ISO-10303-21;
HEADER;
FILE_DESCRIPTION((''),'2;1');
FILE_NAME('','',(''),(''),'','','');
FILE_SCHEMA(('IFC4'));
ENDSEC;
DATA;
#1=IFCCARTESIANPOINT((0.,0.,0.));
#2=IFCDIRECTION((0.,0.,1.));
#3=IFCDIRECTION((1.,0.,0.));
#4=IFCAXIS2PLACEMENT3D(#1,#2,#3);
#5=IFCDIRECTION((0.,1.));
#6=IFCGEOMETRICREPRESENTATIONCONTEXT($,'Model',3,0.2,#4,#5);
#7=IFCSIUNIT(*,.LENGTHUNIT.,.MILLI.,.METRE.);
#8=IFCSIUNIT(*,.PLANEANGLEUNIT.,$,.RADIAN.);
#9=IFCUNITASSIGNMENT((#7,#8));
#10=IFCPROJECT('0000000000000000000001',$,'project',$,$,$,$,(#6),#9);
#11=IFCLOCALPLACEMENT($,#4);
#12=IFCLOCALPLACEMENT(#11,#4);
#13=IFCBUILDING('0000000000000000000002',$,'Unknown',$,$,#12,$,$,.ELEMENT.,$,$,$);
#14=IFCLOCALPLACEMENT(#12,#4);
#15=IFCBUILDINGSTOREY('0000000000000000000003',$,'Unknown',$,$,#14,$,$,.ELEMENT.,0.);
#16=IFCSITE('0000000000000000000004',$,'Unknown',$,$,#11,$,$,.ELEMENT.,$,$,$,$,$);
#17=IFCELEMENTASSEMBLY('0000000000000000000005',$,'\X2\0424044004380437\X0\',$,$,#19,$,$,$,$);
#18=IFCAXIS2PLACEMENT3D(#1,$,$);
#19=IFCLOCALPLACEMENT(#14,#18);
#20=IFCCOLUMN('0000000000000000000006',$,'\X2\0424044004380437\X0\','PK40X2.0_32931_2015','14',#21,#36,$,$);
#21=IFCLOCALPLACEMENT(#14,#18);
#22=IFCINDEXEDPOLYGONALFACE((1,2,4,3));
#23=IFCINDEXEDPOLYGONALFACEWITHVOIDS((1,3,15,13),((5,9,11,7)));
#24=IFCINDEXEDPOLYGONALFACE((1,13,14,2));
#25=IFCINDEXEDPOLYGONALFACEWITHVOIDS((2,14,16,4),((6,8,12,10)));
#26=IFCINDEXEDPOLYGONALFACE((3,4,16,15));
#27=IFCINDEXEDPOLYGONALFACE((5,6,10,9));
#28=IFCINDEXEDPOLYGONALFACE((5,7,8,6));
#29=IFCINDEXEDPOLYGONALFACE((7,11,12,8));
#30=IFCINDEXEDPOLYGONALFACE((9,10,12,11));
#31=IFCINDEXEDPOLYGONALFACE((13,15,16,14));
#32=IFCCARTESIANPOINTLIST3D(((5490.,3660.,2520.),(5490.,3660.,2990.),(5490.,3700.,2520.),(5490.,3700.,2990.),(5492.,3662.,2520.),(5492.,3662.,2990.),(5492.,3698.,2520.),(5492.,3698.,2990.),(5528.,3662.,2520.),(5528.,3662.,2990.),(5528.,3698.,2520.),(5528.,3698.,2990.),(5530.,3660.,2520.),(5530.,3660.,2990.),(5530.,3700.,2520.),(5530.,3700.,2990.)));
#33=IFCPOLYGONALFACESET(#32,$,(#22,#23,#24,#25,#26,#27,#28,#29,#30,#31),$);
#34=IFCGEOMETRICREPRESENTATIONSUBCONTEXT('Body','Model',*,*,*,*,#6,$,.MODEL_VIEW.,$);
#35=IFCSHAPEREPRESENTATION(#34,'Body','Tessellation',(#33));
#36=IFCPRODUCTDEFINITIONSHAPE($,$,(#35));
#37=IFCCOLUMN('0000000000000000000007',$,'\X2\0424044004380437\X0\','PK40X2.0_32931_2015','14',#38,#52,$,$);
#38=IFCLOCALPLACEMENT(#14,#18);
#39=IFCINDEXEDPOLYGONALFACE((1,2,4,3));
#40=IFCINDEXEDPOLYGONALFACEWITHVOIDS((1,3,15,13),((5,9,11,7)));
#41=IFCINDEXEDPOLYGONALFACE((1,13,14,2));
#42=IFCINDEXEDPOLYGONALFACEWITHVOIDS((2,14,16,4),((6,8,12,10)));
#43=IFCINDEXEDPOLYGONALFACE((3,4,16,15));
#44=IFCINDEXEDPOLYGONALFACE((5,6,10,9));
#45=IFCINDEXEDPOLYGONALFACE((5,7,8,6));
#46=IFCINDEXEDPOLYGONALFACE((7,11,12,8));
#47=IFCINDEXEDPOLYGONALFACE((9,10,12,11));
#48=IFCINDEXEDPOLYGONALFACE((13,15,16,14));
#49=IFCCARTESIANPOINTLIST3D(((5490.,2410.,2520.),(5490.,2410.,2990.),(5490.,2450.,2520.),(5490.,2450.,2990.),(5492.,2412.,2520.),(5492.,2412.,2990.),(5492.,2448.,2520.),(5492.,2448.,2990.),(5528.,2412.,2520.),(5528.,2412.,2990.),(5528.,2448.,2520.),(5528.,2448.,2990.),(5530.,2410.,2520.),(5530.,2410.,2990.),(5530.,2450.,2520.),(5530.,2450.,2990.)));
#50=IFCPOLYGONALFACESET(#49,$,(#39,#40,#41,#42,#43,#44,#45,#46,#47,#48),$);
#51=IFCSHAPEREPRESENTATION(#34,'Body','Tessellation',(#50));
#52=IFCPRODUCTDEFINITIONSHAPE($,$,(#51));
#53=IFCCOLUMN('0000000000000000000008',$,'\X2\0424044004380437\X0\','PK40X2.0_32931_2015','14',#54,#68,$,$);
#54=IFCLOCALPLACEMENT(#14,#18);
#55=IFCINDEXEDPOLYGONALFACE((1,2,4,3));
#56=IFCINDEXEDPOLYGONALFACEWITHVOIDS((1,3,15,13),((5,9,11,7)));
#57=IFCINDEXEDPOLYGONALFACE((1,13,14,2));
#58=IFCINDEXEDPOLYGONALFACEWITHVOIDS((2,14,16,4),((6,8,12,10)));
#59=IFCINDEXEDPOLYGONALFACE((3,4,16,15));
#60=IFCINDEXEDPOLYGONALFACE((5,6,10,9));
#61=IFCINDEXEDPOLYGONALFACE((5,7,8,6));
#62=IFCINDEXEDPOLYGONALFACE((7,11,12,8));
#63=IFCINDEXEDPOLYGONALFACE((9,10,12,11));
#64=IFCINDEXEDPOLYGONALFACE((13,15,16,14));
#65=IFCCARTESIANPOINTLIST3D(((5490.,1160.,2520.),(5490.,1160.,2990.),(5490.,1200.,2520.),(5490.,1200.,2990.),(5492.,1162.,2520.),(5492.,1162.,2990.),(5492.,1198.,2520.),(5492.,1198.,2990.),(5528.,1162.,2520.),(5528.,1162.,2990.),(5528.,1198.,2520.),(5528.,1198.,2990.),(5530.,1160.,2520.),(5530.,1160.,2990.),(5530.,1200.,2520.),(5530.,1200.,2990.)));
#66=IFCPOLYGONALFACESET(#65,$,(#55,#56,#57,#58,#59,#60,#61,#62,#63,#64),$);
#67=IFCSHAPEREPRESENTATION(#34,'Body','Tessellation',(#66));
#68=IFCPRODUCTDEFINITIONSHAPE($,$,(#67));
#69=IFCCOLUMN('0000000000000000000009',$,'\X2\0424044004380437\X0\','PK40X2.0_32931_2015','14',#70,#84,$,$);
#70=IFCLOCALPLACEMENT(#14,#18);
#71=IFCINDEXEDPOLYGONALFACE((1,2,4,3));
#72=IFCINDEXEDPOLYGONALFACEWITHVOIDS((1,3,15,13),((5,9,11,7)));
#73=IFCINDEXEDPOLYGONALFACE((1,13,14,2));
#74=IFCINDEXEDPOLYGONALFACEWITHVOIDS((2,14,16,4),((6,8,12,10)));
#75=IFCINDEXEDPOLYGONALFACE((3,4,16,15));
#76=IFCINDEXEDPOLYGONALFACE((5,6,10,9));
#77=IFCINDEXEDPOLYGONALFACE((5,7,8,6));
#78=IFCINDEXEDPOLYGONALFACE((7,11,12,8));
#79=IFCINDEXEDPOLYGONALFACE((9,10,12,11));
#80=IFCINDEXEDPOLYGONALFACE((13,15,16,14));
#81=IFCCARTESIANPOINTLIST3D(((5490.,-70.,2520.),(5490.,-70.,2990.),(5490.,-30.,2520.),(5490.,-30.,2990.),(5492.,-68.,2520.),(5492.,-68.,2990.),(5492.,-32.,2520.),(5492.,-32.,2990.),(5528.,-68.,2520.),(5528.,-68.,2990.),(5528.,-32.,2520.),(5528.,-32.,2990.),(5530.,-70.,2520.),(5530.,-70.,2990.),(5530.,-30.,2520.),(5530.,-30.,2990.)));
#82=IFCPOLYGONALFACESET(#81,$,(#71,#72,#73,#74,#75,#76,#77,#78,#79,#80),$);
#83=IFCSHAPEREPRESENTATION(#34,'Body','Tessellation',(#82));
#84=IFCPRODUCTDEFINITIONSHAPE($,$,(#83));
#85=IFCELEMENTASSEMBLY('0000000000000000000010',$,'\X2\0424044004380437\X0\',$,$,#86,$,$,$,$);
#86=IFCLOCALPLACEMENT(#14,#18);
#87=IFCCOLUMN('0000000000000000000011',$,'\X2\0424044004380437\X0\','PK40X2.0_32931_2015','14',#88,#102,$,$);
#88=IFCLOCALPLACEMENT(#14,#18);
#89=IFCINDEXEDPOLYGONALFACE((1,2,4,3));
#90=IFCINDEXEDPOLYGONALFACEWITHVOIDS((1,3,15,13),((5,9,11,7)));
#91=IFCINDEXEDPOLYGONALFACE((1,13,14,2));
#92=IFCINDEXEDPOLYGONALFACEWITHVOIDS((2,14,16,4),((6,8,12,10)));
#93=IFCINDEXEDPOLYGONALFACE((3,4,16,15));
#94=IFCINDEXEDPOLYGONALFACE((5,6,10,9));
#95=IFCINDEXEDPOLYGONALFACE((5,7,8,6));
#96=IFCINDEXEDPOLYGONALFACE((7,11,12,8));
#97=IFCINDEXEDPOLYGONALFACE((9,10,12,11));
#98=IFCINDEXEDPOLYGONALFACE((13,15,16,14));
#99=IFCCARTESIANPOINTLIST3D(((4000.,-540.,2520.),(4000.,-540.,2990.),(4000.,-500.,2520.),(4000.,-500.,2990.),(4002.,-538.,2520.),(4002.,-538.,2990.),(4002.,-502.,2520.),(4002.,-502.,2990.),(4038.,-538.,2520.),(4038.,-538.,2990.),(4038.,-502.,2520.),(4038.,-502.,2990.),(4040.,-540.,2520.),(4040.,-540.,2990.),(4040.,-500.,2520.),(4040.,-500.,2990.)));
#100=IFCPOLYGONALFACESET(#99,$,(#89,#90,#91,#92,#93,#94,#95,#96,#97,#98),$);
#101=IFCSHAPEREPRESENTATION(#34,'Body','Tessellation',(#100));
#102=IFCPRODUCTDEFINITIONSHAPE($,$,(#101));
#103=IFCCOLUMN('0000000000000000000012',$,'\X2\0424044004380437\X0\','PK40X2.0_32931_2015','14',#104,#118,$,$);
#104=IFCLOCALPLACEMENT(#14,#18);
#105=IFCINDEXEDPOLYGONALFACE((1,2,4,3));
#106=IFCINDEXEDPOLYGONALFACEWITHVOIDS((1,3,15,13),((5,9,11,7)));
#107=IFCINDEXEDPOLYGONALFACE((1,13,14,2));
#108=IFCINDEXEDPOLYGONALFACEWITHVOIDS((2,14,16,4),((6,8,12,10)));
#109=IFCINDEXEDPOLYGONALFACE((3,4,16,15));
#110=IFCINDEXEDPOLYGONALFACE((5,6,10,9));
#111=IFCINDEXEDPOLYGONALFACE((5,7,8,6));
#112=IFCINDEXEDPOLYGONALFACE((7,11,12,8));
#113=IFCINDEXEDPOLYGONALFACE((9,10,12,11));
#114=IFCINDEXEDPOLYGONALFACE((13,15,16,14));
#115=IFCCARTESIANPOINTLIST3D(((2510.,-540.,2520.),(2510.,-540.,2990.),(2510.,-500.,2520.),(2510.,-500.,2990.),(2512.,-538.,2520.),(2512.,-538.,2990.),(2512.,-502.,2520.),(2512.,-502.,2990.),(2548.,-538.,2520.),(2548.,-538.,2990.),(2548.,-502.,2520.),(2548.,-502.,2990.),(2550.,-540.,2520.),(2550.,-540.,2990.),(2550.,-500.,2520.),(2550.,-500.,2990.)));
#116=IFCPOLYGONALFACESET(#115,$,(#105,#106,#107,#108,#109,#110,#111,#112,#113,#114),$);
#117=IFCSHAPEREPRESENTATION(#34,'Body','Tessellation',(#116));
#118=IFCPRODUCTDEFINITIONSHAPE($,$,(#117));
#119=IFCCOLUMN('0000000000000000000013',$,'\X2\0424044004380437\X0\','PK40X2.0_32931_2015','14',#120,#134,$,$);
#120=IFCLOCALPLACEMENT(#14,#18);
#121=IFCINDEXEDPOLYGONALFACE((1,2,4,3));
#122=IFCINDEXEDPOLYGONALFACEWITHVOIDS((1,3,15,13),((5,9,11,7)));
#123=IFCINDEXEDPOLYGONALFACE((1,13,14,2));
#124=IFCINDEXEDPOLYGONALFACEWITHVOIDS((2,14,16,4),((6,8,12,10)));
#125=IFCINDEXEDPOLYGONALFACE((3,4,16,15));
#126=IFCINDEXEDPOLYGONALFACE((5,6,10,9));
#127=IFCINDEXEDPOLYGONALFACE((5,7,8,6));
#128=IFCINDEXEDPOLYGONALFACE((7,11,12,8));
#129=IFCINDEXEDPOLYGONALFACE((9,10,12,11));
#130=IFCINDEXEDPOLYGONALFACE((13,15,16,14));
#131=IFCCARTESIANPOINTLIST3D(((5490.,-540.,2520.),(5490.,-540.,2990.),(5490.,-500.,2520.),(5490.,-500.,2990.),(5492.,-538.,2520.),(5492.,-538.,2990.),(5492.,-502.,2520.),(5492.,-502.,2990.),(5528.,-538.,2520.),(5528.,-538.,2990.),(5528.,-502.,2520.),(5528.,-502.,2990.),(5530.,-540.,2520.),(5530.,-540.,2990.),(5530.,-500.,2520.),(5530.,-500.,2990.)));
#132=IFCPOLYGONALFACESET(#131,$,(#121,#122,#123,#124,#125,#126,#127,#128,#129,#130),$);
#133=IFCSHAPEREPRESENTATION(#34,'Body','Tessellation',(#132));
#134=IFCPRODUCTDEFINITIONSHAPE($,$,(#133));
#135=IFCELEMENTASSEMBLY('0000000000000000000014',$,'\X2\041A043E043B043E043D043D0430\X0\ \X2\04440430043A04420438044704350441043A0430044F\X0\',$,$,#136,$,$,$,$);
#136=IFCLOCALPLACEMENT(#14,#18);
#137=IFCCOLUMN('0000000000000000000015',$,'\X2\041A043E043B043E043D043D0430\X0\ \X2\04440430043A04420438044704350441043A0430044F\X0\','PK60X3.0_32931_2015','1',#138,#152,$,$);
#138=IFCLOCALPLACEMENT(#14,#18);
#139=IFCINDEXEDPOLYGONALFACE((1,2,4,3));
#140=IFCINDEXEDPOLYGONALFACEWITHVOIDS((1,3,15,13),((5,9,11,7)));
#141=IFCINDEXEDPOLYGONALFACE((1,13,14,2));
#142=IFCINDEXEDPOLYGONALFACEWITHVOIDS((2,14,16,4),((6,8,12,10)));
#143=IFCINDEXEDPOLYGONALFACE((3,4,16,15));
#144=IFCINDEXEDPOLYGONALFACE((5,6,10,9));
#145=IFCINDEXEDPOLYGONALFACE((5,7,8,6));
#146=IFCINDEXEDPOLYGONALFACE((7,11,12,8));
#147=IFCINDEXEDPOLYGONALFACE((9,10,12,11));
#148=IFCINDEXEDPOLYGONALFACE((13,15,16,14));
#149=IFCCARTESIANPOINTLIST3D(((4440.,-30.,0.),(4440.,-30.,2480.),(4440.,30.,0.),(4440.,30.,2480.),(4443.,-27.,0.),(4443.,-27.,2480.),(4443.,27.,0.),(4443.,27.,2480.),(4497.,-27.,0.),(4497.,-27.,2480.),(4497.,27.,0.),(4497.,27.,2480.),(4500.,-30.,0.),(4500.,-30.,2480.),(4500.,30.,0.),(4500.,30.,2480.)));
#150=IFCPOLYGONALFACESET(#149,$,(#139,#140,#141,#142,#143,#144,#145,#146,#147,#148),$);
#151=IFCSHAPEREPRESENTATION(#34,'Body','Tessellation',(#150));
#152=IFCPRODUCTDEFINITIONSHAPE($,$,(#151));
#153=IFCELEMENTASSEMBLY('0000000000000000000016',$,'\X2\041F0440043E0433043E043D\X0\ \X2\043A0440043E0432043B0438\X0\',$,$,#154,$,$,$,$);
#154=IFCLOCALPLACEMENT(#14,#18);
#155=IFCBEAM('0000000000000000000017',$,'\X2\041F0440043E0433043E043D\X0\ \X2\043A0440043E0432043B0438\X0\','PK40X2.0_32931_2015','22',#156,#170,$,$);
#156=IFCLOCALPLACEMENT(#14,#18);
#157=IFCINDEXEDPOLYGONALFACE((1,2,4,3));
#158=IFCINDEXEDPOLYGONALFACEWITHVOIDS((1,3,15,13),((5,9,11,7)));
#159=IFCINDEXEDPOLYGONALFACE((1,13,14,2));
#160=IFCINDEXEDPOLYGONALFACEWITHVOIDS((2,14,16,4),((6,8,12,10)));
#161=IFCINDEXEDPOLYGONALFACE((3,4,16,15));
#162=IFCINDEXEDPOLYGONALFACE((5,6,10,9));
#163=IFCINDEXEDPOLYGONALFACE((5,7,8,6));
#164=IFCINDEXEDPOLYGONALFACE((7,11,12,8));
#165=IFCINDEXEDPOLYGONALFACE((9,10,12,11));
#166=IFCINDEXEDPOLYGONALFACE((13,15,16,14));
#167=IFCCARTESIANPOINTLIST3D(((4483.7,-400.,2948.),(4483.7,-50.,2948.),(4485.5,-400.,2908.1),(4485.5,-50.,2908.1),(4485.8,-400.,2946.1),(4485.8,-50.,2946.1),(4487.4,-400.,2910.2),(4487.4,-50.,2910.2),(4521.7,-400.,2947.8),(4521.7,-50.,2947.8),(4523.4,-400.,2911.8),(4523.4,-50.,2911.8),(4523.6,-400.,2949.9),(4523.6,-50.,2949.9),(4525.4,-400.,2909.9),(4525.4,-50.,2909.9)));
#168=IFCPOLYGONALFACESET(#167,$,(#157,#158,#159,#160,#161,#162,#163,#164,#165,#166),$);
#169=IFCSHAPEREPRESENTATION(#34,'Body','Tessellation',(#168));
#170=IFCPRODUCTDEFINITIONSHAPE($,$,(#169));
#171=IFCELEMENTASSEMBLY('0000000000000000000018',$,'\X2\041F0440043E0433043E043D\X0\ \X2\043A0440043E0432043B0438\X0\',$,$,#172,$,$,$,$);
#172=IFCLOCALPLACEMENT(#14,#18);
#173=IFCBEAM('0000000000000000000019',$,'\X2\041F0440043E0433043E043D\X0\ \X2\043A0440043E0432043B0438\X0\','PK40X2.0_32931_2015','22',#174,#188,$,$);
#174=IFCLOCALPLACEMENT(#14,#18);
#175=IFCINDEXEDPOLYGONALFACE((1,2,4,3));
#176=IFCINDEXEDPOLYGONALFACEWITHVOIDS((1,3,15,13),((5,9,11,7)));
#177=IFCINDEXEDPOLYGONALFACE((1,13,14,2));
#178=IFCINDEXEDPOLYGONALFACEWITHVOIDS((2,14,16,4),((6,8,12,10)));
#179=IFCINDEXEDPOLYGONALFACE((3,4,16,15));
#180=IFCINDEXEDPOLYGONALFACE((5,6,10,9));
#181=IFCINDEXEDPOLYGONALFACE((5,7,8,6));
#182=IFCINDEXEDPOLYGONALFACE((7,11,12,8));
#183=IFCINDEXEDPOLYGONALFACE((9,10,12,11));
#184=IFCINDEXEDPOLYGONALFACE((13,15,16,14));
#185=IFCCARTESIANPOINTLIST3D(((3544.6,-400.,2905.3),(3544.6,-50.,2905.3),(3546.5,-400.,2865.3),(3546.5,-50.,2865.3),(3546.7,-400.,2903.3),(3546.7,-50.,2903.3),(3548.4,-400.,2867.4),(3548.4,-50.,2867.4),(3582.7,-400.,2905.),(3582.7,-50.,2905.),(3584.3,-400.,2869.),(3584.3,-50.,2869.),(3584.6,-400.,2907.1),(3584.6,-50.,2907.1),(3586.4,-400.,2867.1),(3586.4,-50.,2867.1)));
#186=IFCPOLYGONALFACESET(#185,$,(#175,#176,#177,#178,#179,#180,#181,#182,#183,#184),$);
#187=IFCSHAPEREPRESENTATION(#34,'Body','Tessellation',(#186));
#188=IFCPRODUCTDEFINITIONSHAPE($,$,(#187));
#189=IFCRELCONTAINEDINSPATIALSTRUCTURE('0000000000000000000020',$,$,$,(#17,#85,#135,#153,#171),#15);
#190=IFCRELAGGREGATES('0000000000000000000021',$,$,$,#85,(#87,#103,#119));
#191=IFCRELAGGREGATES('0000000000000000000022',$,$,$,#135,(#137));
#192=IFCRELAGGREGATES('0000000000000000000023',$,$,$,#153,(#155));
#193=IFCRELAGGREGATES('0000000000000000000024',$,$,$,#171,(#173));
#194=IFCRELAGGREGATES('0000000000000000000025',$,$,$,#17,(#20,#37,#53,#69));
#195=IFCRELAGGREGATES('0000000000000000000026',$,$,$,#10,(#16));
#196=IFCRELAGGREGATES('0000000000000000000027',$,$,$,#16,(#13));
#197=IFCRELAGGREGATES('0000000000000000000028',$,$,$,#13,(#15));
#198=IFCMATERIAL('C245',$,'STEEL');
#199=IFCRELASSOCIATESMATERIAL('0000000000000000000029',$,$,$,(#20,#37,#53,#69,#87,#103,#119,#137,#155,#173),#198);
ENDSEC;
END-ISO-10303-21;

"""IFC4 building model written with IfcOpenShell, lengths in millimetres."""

from ifc_helpers import new_model, si_unit, direction, frame, origin_with_axes, place, context, subcontext, project, spatial, line, indexed_curve, outline, extrude, material, element, aggregate, save


model = new_model("IFC4")

# Units and contexts
model_context = context("Model", 3, precision=0.2, world=origin_with_axes(), true_north=direction((0.0, 1.0)))
body_context = subcontext(model_context, "Body", "Model", "MODEL_VIEW")
ifc_project = project(units=[si_unit("LENGTHUNIT", "METRE", prefix="MILLI"), si_unit("PLANEANGLEUNIT", "RADIAN")], contexts=[model_context])

# Site, building, storey
site_placement = place(None, origin_with_axes())
site = spatial("IfcSite", under=ifc_project, at=site_placement, Name="Unknown", CompositionType="ELEMENT")
building_placement = place(site_placement, origin_with_axes())
building = spatial("IfcBuilding", under=site, at=building_placement, Name="Unknown", CompositionType="ELEMENT")
storey_placement = place(building_placement, origin_with_axes())
storey = spatial("IfcBuildingStorey", under=building, at=storey_placement, Name="Unknown", CompositionType="ELEMENT", Elevation=0.0)

# Element assemblies, columns
assembly_1_placement = place(storey_placement, frame((5510.0, -500.0, 3010.0), z_axis=(1.0, 0.0, 0.0), x_axis=(0.0, 1.0, 0.0)))
assembly_1 = element("IfcElementAssembly", 1, at=assembly_1_placement, inside=storey, Name="Фриз")
ifc_material = material(Name="C245", Category="STEEL")
column_1_placement = place(assembly_1_placement, frame((4180.0, -490.0, 0.0), z_axis=(-1.0, 0.0, 0.0), x_axis=(0.0, 1.0, 0.0)))
column_1 = element("IfcColumn", 2, at=column_1_placement, material=ifc_material, Name="Фриз", Description="PK40X2.0_32931_2015", ObjectType="14", context=body_context, shape_type="SolidModel", body=[
    extrude(outline(indexed_curve([(-20.0, -20.0), (20.0, -20.0), (20.0, 20.0), (-20.0, 20.0)], segments=[line(1, 2, 3, 4, 1)]), holes=[indexed_curve([(-18.0, -18.0), (-18.0, 18.0), (18.0, 18.0), (18.0, -18.0)], segments=[line(1, 2, 3, 4, 1)])]), frame((0.0, 0.0, 0.0), z_axis=(-1.0, 0.0, 0.0), x_axis=(0.0, 0.0, 1.0)), (0.0, 0.0, -1.0), 470.0),
])
column_2_placement = place(assembly_1_placement, frame((2930.0, -490.0, 0.0), z_axis=(-1.0, 0.0, 0.0), x_axis=(0.0, 1.0, 0.0)))
column_2 = element("IfcColumn", 3, at=column_2_placement, material=ifc_material, Name="Фриз", Description="PK40X2.0_32931_2015", ObjectType="14", context=body_context, shape_type="SolidModel", body=[
    extrude(outline(indexed_curve([(-20.0, -20.0), (20.0, -20.0), (20.0, 20.0), (-20.0, 20.0)], segments=[line(1, 2, 3, 4, 1)]), holes=[indexed_curve([(-18.0, -18.0), (-18.0, 18.0), (18.0, 18.0), (18.0, -18.0)], segments=[line(1, 2, 3, 4, 1)])]), frame((0.0, 0.0, 0.0), z_axis=(-1.0, 0.0, 0.0), x_axis=(0.0, 0.0, 1.0)), (0.0, 0.0, -1.0), 470.0),
])
column_3_placement = place(assembly_1_placement, frame((1680.0, -490.0, 0.0), z_axis=(-1.0, 0.0, 0.0), x_axis=(0.0, 1.0, 0.0)))
column_3 = element("IfcColumn", 4, at=column_3_placement, material=ifc_material, Name="Фриз", Description="PK40X2.0_32931_2015", ObjectType="14", context=body_context, shape_type="SolidModel", body=[
    extrude(outline(indexed_curve([(-20.0, -20.0), (20.0, -20.0), (20.0, 20.0), (-20.0, 20.0)], segments=[line(1, 2, 3, 4, 1)]), holes=[indexed_curve([(-18.0, -18.0), (-18.0, 18.0), (18.0, 18.0), (18.0, -18.0)], segments=[line(1, 2, 3, 4, 1)])]), frame((0.0, 0.0, 0.0), z_axis=(-1.0, 0.0, 0.0), x_axis=(0.0, 0.0, 1.0)), (0.0, 0.0, -1.0), 470.0),
])
column_4_placement = place(assembly_1_placement, frame((450.0, -490.0, 0.0), z_axis=(-1.0, 0.0, 0.0), x_axis=(0.0, 1.0, 0.0)))
column_4 = element("IfcColumn", 5, at=column_4_placement, material=ifc_material, Name="Фриз", Description="PK40X2.0_32931_2015", ObjectType="14", context=body_context, shape_type="SolidModel", body=[
    extrude(outline(indexed_curve([(-20.0, -20.0), (20.0, -20.0), (20.0, 20.0), (-20.0, 20.0)], segments=[line(1, 2, 3, 4, 1)]), holes=[indexed_curve([(-18.0, -18.0), (-18.0, 18.0), (18.0, 18.0), (18.0, -18.0)], segments=[line(1, 2, 3, 4, 1)])]), frame((0.0, 0.0, 0.0), z_axis=(-1.0, 0.0, 0.0), x_axis=(0.0, 0.0, 1.0)), (0.0, 0.0, -1.0), 470.0),
])
assembly_2_placement = place(storey_placement, frame((-470.0, -520.0, 3010.0), z_axis=(0.0, -1.0, 0.0), x_axis=(1.0, 0.0, 0.0)))
assembly_2 = element("IfcElementAssembly", 6, at=assembly_2_placement, inside=storey, Name="Фриз")
column_5_placement = place(assembly_2_placement, frame((4490.0, -490.0, 0.0), z_axis=(0.0, 0.0, -1.0), x_axis=(0.0, 1.0, 0.0)))
column_5 = element("IfcColumn", 7, at=column_5_placement, material=ifc_material, Name="Фриз", Description="PK40X2.0_32931_2015", ObjectType="14", context=body_context, shape_type="SolidModel", body=[
    extrude(outline(indexed_curve([(-20.0, -20.0), (20.0, -20.0), (20.0, 20.0), (-20.0, 20.0)], segments=[line(1, 2, 3, 4, 1)]), holes=[indexed_curve([(-18.0, -18.0), (-18.0, 18.0), (18.0, 18.0), (18.0, -18.0)], segments=[line(1, 2, 3, 4, 1)])]), frame((0.0, 0.0, 0.0), z_axis=(-1.0, 0.0, 0.0), x_axis=(0.0, 0.0, 1.0)), (0.0, 0.0, -1.0), 470.0),
])
column_6_placement = place(assembly_2_placement, frame((3000.0, -490.0, 0.0), z_axis=(0.0, 0.0, -1.0), x_axis=(0.0, 1.0, 0.0)))
column_6 = element("IfcColumn", 8, at=column_6_placement, material=ifc_material, Name="Фриз", Description="PK40X2.0_32931_2015", ObjectType="14", context=body_context, shape_type="SolidModel", body=[
    extrude(outline(indexed_curve([(-20.0, -20.0), (20.0, -20.0), (20.0, 20.0), (-20.0, 20.0)], segments=[line(1, 2, 3, 4, 1)]), holes=[indexed_curve([(-18.0, -18.0), (-18.0, 18.0), (18.0, 18.0), (18.0, -18.0)], segments=[line(1, 2, 3, 4, 1)])]), frame((0.0, 0.0, 0.0), z_axis=(-1.0, 0.0, 0.0), x_axis=(0.0, 0.0, 1.0)), (0.0, 0.0, -1.0), 470.0),
])
column_7_placement = place(assembly_2_placement, frame((5980.0, -490.0, 0.0), z_axis=(0.0, 0.0, 1.0), x_axis=(0.0, 1.0, 0.0)))
column_7 = element("IfcColumn", 9, at=column_7_placement, material=ifc_material, Name="Фриз", Description="PK40X2.0_32931_2015", ObjectType="14", context=body_context, shape_type="SolidModel", body=[
    extrude(outline(indexed_curve([(-20.0, -20.0), (20.0, -20.0), (20.0, 20.0), (-20.0, 20.0)], segments=[line(1, 2, 3, 4, 1)]), holes=[indexed_curve([(-18.0, -18.0), (-18.0, 18.0), (18.0, 18.0), (18.0, -18.0)], segments=[line(1, 2, 3, 4, 1)])]), frame((0.0, 0.0, 0.0), z_axis=(-1.0, 0.0, 0.0), x_axis=(0.0, 0.0, 1.0)), (0.0, 0.0, -1.0), 470.0),
])
aggregate(assembly_2, [column_5, column_6, column_7])

# Element assembly, column
assembly_3_placement = place(storey_placement, frame((4470.0, 0.0, 0.0), z_axis=(-1.0, 0.0, 0.0), x_axis=(0.0, 0.0, 1.0)))
assembly_3 = element("IfcElementAssembly", 10, at=assembly_3_placement, inside=storey, Name="Колонна фактическая")
column_8_placement = place(assembly_3_placement, origin_with_axes())
column_8 = element("IfcColumn", 11, at=column_8_placement, material=ifc_material, Name="Колонна фактическая", Description="PK60X3.0_32931_2015", ObjectType="1", context=body_context, shape_type="SolidModel", body=[
    extrude(outline(indexed_curve([(-30.0, -30.0), (30.0, -30.0), (30.0, 30.0), (-30.0, 30.0)], segments=[line(1, 2, 3, 4, 1)]), holes=[indexed_curve([(-27.0, -27.0), (-27.0, 27.0), (27.0, 27.0), (27.0, -27.0)], segments=[line(1, 2, 3, 4, 1)])]), frame((0.0, 0.0, 0.0), z_axis=(-1.0, 0.0, 0.0), x_axis=(0.0, 0.0, 1.0)), (0.0, 0.0, -1.0), 2480.0),
])
aggregate(assembly_3, [column_8])

# Element assemblies, beams
assembly_4_placement = place(storey_placement, frame((4504.6, -50.0, 2929.0), z_axis=(-0.998964, 0.0, -0.045508), x_axis=(0.0, -1.0, 0.0)))
assembly_4 = element("IfcElementAssembly", 12, at=assembly_4_placement, inside=storey, Name="Прогон кровли")
beam_1_placement = place(assembly_4_placement, origin_with_axes())
beam_1 = element("IfcBeam", 13, at=beam_1_placement, material=ifc_material, Name="Прогон кровли", Description="PK40X2.0_32931_2015", ObjectType="22", context=body_context, shape_type="SolidModel", body=[
    extrude(outline(indexed_curve([(-20.0, -20.0), (20.0, -20.0), (20.0, 20.0), (-20.0, 20.0)], segments=[line(1, 2, 3, 4, 1)]), holes=[indexed_curve([(-18.0, -18.0), (-18.0, 18.0), (18.0, 18.0), (18.0, -18.0)], segments=[line(1, 2, 3, 4, 1)])]), frame((0.0, 0.0, 0.0), z_axis=(-1.0, 0.0, 0.0), x_axis=(0.0, 0.0, 1.0)), (0.0, 0.0, -1.0), 350.0),
])
aggregate(assembly_4, [beam_1])
assembly_5_placement = place(storey_placement, frame((3565.5, -50.0, 2886.2), z_axis=(-0.998964, 0.0, -0.045508), x_axis=(0.0, -1.0, 0.0)))
assembly_5 = element("IfcElementAssembly", 14, at=assembly_5_placement, inside=storey, Name="Прогон кровли")
beam_2_placement = place(assembly_5_placement, origin_with_axes())
beam_2 = element("IfcBeam", 15, at=beam_2_placement, material=ifc_material, Name="Прогон кровли", Description="PK40X2.0_32931_2015", ObjectType="22", context=body_context, shape_type="SolidModel", body=[
    extrude(outline(indexed_curve([(-20.0, -20.0), (20.0, -20.0), (20.0, 20.0), (-20.0, 20.0)], segments=[line(1, 2, 3, 4, 1)]), holes=[indexed_curve([(-18.0, -18.0), (-18.0, 18.0), (18.0, 18.0), (18.0, -18.0)], segments=[line(1, 2, 3, 4, 1)])]), frame((0.0, 0.0, 0.0), z_axis=(-1.0, 0.0, 0.0), x_axis=(0.0, 0.0, 1.0)), (0.0, 0.0, -1.0), 350.0),
])
aggregate(assembly_5, [beam_2])

aggregate(assembly_1, [column_1, column_2, column_3, column_4])

save(model, "model.ifc")
